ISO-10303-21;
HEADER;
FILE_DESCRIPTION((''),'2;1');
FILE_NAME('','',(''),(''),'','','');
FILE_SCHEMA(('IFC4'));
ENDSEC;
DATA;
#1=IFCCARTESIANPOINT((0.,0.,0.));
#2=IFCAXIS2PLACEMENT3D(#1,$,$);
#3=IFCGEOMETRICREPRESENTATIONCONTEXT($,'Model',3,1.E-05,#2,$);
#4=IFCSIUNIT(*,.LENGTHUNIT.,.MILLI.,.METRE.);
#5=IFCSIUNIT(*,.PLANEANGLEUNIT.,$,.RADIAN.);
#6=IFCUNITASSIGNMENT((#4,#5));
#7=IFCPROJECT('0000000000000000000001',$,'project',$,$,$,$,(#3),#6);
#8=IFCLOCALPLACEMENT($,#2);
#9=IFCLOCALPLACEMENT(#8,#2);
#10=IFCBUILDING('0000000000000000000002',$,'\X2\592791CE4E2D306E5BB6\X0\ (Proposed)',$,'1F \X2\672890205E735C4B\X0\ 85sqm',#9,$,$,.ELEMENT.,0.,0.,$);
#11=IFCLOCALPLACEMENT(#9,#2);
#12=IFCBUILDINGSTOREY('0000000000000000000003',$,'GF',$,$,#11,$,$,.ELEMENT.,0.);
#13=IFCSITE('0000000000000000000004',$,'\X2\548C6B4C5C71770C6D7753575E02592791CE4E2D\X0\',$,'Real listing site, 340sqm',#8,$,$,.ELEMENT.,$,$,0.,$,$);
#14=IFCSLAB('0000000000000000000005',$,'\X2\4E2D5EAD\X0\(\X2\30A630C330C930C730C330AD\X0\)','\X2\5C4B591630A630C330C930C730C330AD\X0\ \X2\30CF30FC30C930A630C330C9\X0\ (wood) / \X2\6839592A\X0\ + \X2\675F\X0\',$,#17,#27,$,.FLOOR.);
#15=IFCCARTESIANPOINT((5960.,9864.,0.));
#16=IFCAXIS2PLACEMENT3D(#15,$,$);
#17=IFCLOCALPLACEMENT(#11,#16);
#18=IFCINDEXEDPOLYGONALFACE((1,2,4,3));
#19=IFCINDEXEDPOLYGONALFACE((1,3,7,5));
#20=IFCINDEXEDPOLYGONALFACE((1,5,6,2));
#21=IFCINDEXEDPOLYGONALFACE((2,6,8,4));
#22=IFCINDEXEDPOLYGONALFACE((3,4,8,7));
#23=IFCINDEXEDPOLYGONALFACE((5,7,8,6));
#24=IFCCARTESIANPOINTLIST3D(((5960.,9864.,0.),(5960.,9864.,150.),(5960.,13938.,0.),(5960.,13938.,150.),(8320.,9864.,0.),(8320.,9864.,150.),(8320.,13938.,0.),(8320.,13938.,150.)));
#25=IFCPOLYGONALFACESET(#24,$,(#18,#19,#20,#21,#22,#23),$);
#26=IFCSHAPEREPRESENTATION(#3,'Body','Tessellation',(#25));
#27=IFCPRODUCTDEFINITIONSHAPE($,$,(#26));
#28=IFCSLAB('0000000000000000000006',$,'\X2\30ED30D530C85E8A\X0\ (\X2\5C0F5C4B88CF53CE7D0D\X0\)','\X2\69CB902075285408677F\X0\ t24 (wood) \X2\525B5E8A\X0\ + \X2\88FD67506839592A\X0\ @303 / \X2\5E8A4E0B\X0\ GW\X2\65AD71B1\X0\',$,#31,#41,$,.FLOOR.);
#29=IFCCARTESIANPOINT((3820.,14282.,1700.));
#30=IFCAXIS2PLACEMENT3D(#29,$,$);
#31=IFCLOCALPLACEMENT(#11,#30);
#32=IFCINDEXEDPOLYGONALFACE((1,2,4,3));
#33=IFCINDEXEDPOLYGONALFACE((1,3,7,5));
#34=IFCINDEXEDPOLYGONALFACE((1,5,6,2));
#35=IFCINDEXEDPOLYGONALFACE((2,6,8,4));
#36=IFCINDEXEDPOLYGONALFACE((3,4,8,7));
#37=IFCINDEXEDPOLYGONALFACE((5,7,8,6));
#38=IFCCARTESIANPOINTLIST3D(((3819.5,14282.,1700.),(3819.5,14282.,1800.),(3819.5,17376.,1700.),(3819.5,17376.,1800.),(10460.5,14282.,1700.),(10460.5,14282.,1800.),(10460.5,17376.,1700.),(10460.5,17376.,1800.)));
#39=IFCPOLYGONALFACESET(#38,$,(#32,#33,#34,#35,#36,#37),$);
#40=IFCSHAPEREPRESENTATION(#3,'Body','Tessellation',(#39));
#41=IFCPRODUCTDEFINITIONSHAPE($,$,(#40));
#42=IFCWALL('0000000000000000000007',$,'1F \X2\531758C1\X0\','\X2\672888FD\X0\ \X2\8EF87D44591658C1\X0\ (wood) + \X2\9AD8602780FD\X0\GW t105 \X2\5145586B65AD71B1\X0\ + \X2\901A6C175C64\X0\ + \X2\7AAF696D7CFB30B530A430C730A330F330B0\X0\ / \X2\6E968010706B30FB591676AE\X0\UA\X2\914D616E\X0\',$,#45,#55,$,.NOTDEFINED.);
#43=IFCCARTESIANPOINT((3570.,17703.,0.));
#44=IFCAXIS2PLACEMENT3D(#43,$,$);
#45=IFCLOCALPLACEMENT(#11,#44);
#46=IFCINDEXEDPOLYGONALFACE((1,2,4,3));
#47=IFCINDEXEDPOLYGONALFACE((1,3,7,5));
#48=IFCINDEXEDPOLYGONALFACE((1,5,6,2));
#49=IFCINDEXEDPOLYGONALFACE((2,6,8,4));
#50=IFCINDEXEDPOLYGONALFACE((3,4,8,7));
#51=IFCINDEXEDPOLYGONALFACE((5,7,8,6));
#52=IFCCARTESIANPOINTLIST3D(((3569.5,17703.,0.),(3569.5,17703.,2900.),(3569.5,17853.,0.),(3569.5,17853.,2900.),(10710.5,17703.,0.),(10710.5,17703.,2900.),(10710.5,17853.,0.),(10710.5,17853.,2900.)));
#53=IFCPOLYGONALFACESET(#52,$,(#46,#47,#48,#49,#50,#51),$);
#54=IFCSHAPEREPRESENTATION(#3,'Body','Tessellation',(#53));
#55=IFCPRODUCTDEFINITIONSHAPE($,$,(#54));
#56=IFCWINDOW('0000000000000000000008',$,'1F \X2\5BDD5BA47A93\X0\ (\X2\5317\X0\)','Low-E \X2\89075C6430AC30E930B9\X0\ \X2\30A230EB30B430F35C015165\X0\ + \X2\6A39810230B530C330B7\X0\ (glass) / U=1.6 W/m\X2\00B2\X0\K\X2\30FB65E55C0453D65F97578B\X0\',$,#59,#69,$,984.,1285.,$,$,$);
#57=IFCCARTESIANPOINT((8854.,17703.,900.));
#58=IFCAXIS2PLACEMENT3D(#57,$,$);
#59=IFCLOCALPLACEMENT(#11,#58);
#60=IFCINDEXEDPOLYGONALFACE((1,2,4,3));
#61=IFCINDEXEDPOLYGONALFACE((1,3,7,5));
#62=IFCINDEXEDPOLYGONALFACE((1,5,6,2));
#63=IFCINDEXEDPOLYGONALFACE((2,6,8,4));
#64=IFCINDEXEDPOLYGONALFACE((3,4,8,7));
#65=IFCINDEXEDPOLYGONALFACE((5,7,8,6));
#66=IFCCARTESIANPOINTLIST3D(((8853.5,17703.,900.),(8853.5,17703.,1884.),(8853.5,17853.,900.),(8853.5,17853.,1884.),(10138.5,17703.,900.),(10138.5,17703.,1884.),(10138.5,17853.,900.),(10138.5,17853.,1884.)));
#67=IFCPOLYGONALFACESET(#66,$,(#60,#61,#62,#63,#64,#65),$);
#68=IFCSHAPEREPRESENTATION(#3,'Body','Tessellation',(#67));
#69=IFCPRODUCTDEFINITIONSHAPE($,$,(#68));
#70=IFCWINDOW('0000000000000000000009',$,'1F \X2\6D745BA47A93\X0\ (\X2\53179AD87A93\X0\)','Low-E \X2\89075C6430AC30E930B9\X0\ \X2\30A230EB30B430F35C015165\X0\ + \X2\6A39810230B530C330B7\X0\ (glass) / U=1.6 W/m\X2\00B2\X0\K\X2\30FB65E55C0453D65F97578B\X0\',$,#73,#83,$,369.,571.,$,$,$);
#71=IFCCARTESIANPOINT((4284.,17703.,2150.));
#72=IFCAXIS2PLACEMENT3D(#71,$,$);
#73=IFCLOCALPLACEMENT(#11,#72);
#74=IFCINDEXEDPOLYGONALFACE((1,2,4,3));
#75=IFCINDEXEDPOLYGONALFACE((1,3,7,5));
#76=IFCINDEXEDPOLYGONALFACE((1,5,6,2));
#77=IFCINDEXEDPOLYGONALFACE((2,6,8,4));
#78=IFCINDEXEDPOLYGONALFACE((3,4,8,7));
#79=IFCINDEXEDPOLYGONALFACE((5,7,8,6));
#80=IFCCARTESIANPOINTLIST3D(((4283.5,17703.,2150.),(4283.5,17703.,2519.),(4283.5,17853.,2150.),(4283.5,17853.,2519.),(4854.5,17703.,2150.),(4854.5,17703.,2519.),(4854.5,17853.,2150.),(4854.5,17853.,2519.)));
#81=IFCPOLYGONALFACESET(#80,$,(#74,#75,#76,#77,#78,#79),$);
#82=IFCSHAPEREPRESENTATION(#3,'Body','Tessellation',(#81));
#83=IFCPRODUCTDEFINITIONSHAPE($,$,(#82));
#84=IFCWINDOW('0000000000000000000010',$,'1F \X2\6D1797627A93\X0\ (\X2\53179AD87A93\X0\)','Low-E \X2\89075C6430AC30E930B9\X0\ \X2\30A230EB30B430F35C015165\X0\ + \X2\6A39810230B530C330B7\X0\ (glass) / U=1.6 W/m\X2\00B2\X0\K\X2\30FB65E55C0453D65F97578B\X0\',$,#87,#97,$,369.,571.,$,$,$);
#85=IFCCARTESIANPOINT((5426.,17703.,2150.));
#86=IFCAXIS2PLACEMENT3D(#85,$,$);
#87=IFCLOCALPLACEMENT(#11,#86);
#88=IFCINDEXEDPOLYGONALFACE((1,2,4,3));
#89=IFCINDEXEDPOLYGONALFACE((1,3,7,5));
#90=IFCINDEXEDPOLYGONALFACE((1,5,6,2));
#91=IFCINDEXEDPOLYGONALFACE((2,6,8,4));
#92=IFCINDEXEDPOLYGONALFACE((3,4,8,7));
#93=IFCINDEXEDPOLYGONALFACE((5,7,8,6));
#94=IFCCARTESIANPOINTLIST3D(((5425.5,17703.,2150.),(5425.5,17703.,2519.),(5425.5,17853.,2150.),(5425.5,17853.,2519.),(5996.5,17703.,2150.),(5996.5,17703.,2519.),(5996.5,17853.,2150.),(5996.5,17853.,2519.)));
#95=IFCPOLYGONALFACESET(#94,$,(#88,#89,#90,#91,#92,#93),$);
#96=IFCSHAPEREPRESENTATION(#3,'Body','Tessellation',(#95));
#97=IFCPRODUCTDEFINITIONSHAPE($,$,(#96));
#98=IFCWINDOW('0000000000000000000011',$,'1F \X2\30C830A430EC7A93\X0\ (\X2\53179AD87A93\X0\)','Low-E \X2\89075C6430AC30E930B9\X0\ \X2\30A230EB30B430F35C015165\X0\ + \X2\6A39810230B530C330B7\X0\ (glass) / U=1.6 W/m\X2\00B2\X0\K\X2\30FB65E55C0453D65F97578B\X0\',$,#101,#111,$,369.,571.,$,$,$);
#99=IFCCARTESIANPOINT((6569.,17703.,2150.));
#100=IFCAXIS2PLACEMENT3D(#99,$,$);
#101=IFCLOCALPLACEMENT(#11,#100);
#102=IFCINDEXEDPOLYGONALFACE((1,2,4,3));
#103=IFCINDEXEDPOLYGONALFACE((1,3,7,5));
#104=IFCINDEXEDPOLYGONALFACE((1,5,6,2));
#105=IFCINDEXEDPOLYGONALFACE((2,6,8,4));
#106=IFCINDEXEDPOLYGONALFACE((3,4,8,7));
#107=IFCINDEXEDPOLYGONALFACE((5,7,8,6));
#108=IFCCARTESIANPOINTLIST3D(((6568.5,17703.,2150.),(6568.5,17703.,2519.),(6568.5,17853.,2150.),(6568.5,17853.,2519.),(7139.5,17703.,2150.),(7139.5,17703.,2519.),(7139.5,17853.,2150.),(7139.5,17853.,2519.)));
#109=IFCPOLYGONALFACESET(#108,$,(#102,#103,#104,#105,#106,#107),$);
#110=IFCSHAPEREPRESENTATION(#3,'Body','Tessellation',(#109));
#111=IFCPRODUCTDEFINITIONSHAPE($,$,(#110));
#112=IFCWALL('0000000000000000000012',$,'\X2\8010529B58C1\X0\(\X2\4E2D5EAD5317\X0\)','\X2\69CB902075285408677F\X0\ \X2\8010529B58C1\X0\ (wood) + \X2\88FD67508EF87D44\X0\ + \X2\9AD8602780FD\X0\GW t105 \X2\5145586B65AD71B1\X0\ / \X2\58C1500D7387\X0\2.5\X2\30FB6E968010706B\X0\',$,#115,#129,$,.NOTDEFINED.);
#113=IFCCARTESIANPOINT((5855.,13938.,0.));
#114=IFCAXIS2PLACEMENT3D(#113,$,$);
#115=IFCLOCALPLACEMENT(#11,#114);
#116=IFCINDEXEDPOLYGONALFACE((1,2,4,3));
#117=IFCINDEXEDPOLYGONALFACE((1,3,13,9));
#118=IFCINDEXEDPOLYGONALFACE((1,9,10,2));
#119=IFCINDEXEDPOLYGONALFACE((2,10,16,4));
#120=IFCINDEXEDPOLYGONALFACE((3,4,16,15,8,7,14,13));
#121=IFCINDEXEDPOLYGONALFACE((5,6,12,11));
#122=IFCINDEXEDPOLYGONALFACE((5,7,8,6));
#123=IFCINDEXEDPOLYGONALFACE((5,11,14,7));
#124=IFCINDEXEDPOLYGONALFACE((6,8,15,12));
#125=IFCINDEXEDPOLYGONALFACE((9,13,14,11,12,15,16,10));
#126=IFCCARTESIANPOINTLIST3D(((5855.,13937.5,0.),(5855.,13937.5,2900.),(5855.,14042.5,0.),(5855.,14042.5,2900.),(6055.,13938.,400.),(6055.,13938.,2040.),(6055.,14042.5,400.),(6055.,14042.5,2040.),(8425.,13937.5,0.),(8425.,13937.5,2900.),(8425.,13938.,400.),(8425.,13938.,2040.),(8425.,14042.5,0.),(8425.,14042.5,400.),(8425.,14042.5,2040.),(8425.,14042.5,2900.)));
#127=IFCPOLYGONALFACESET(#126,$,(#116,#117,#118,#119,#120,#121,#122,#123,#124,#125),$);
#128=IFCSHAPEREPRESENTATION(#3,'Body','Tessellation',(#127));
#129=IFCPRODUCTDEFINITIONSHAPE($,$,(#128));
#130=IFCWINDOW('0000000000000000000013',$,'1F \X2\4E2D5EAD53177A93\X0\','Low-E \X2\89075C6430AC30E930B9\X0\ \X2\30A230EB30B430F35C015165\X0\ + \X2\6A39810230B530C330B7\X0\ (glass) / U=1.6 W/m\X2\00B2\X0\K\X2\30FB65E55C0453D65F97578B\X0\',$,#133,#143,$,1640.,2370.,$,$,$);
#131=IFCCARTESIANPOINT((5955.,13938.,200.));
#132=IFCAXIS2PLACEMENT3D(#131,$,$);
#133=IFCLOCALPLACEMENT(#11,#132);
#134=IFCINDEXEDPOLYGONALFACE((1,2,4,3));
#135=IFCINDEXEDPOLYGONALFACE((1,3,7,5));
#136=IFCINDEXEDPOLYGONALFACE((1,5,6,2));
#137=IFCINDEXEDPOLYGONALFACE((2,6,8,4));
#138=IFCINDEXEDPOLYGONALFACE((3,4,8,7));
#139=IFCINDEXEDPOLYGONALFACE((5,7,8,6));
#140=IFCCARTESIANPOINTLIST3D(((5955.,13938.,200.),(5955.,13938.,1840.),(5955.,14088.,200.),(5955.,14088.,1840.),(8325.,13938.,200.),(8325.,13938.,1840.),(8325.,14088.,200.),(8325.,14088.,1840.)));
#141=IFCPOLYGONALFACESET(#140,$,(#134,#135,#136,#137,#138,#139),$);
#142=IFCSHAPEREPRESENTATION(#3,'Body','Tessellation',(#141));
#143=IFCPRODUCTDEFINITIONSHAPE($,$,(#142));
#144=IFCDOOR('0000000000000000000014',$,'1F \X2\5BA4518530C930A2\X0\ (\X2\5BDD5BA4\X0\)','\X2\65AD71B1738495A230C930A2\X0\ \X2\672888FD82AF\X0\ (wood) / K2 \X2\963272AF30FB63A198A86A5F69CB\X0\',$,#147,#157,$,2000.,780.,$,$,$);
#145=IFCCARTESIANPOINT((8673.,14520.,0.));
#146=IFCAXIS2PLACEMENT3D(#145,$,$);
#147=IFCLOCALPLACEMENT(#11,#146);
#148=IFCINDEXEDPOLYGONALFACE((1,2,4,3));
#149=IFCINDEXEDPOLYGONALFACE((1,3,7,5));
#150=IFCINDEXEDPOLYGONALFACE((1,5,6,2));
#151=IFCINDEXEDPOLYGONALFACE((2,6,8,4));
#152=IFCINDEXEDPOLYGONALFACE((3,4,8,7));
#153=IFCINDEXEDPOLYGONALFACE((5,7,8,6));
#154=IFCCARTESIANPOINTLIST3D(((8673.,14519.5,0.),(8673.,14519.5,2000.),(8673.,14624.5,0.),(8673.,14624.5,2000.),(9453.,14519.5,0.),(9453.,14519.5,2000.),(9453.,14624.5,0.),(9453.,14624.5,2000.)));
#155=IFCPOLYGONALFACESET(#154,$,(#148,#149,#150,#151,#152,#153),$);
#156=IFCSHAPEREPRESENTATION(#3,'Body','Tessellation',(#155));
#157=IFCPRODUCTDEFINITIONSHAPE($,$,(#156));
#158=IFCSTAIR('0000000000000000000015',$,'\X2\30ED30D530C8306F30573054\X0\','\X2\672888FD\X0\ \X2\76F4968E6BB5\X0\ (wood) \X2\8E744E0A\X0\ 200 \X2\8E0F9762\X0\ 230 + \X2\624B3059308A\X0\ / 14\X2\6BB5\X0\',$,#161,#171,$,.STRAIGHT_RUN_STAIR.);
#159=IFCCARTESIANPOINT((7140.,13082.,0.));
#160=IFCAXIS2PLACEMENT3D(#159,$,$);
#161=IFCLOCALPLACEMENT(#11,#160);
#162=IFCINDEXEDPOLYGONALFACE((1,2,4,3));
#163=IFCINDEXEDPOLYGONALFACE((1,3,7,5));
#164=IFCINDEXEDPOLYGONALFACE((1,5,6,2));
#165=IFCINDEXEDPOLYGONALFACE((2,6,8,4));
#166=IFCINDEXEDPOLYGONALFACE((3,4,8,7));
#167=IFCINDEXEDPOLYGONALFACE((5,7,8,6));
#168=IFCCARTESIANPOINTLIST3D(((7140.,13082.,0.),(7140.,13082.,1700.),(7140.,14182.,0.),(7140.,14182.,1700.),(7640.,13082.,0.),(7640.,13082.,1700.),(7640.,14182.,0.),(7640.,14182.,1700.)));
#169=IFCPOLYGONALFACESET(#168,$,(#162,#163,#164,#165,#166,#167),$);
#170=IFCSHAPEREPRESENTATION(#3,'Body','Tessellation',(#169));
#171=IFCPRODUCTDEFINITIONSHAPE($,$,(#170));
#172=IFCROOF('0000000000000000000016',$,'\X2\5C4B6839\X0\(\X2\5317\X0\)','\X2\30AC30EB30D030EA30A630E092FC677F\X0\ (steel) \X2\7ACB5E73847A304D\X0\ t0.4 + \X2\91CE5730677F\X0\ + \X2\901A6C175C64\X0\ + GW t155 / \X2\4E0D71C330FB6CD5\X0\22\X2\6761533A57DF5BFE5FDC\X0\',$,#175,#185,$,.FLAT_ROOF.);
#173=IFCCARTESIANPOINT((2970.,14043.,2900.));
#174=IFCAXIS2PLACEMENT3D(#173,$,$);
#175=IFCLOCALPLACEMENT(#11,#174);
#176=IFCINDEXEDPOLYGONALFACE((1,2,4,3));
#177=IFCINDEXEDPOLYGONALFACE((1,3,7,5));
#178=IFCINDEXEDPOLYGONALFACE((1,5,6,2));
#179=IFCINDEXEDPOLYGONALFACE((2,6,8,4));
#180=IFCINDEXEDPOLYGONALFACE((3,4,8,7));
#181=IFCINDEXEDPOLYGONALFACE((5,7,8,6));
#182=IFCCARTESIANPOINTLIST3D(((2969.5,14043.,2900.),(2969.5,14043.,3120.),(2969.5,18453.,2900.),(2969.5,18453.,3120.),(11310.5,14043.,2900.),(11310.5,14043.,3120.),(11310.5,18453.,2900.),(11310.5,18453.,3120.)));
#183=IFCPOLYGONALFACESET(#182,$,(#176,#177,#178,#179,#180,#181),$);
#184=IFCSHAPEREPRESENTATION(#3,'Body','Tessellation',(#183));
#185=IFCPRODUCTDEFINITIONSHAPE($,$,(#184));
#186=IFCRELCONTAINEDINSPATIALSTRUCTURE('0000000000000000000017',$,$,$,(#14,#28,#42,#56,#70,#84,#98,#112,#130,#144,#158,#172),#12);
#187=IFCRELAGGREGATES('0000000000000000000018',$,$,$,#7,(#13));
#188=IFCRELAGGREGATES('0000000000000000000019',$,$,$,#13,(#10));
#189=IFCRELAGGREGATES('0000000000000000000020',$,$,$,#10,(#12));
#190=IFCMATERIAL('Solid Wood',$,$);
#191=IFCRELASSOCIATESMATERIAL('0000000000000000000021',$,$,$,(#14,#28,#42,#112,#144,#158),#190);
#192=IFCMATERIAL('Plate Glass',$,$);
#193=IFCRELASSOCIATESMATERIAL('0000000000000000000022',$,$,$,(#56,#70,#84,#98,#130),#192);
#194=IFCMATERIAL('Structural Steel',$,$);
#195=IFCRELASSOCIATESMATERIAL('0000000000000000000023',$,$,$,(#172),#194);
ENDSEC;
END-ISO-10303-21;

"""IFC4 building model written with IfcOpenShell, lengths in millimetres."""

from ifc_helpers import new_model, si_unit, frame, frame_2d, origin, place, context, project, spatial, rectangle, extrude, material, element, fill, save


model = new_model("IFC4")

# Units and contexts
model_context = context("Model", 3, precision=1e-05, world=origin())
ifc_project = project(units=[si_unit("LENGTHUNIT", "METRE", prefix="MILLI"), si_unit("PLANEANGLEUNIT", "RADIAN")], contexts=[model_context])

# Site, building, storey
site_placement = place(None, origin())
site = spatial("IfcSite", under=ifc_project, at=site_placement, Name="和歌山県海南市大野中", ObjectType="Real listing site, 340sqm", CompositionType="ELEMENT", RefElevation=0.0)
building_placement = place(site_placement, origin())
building = spatial("IfcBuilding", under=site, at=building_placement, Name="大野中の家 (Proposed)", ObjectType="1F 木造平屋 85sqm", CompositionType="ELEMENT", ElevationOfRefHeight=0.0, ElevationOfTerrain=0.0)
storey_placement = place(building_placement, origin())
storey = spatial("IfcBuildingStorey", under=building, at=storey_placement, Name="GF", CompositionType="ELEMENT", Elevation=0.0)

# Slabs
ifc_material_1 = material(Name="Solid Wood")
slab_1_placement = place(storey_placement, frame((5960.0, 9864.0, 0.0)))
element("IfcSlab", 1, at=slab_1_placement, inside=storey, material=ifc_material_1, Name="中庭(ウッドデッキ)", Description="屋外ウッドデッキ ハードウッド (wood) / 根太 + 束", PredefinedType="FLOOR", context=model_context, shape_type="SweptSolid", body=[
    extrude(rectangle(XDim=2360.0, YDim=4074.0, at=frame_2d((1180.0, 2037.0))), frame((5960.0, 9864.0, 0.0)), (0.0, 0.0, 1.0), 150.0),
])
slab_2_placement = place(storey_placement, frame((3820.0, 14282.0, 1700.0)))
element("IfcSlab", 2, at=slab_2_placement, inside=storey, material=ifc_material_1, Name="ロフト床 (小屋裏収納)", Description="構造用合板 t24 (wood) 剛床 + 製材根太 @303 / 床下 GW断熱", PredefinedType="FLOOR", context=model_context, shape_type="SweptSolid", body=[
    extrude(rectangle(XDim=6641.0, YDim=3094.0, at=frame_2d((3320.0, 1547.0))), frame((3820.0, 14282.0, 1700.0)), (0.0, 0.0, 1.0), 100.0),
])

# Wall, openings, windows
wall_1_placement = place(storey_placement, frame((3570.0, 17703.0, 0.0)))
wall_1 = element("IfcWall", 3, at=wall_1_placement, inside=storey, material=ifc_material_1, Name="1F 北壁", Description="木製 軸組外壁 (wood) + 高性能GW t105 充填断熱 + 通気層 + 窯業系サイディング / 準耐火・外皮UA配慮", PredefinedType="NOTDEFINED", context=model_context, shape_type="SweptSolid", body=[
    extrude(rectangle(XDim=7141.0, YDim=150.0, at=frame_2d((3570.0, 75.0))), frame((3570.0, 17703.0, 0.0)), (0.0, 0.0, 1.0), 2900.0),
])
opening_1_placement = place(storey_placement, frame((8854.0, 17703.0, 900.0)))
opening_1 = element("IfcOpeningElement", 4, at=opening_1_placement, cuts=wall_1, PredefinedType="NOTDEFINED", context=model_context, shape_type="SweptSolid", body=[
    extrude(rectangle(XDim=1285.0, YDim=150.0, at=frame_2d((642.0, 75.0))), frame((8854.0, 17703.0, 900.0)), (0.0, 0.0, 1.0), 984.0),
])
opening_2_placement = place(storey_placement, frame((4284.0, 17703.0, 2150.0)))
opening_2 = element("IfcOpeningElement", 5, at=opening_2_placement, cuts=wall_1, PredefinedType="NOTDEFINED", context=model_context, shape_type="SweptSolid", body=[
    extrude(rectangle(XDim=571.0, YDim=150.0, at=frame_2d((285.0, 75.0))), frame((4284.0, 17703.0, 2150.0)), (0.0, 0.0, 1.0), 369.0),
])
opening_3_placement = place(storey_placement, frame((5426.0, 17703.0, 2150.0)))
opening_3 = element("IfcOpeningElement", 6, at=opening_3_placement, cuts=wall_1, PredefinedType="NOTDEFINED", context=model_context, shape_type="SweptSolid", body=[
    extrude(rectangle(XDim=571.0, YDim=150.0, at=frame_2d((285.0, 75.0))), frame((5426.0, 17703.0, 2150.0)), (0.0, 0.0, 1.0), 369.0),
])
opening_4_placement = place(storey_placement, frame((6569.0, 17703.0, 2150.0)))
opening_4 = element("IfcOpeningElement", 7, at=opening_4_placement, cuts=wall_1, PredefinedType="NOTDEFINED", context=model_context, shape_type="SweptSolid", body=[
    extrude(rectangle(XDim=571.0, YDim=150.0, at=frame_2d((285.0, 75.0))), frame((6569.0, 17703.0, 2150.0)), (0.0, 0.0, 1.0), 369.0),
])
ifc_material_2 = material(Name="Plate Glass")
window_1_placement = place(storey_placement, frame((8854.0, 17703.0, 900.0)))
window_1 = element("IfcWindow", 8, at=window_1_placement, inside=storey, material=ifc_material_2, Name="1F 寝室窓 (北)", Description="Low-E 複層ガラス アルゴン封入 + 樹脂サッシ (glass) / U=1.6 W/m²K・日射取得型", OverallHeight=984.0, OverallWidth=1285.0, context=model_context, shape_type="SweptSolid", body=[
    extrude(rectangle(XDim=1285.0, YDim=150.0, at=frame_2d((642.0, 75.0))), frame((8854.0, 17703.0, 900.0)), (0.0, 0.0, 1.0), 984.0),
])
fill(opening_1, window_1)
window_2_placement = place(storey_placement, frame((4284.0, 17703.0, 2150.0)))
window_2 = element("IfcWindow", 9, at=window_2_placement, inside=storey, material=ifc_material_2, Name="1F 浴室窓 (北高窓)", Description="Low-E 複層ガラス アルゴン封入 + 樹脂サッシ (glass) / U=1.6 W/m²K・日射取得型", OverallHeight=369.0, OverallWidth=571.0, context=model_context, shape_type="SweptSolid", body=[
    extrude(rectangle(XDim=571.0, YDim=150.0, at=frame_2d((285.0, 75.0))), frame((4284.0, 17703.0, 2150.0)), (0.0, 0.0, 1.0), 369.0),
])
fill(opening_2, window_2)
window_3_placement = place(storey_placement, frame((5426.0, 17703.0, 2150.0)))
window_3 = element("IfcWindow", 10, at=window_3_placement, inside=storey, material=ifc_material_2, Name="1F 洗面窓 (北高窓)", Description="Low-E 複層ガラス アルゴン封入 + 樹脂サッシ (glass) / U=1.6 W/m²K・日射取得型", OverallHeight=369.0, OverallWidth=571.0, context=model_context, shape_type="SweptSolid", body=[
    extrude(rectangle(XDim=571.0, YDim=150.0, at=frame_2d((285.0, 75.0))), frame((5426.0, 17703.0, 2150.0)), (0.0, 0.0, 1.0), 369.0),
])
fill(opening_3, window_3)
window_4_placement = place(storey_placement, frame((6569.0, 17703.0, 2150.0)))
window_4 = element("IfcWindow", 11, at=window_4_placement, inside=storey, material=ifc_material_2, Name="1F トイレ窓 (北高窓)", Description="Low-E 複層ガラス アルゴン封入 + 樹脂サッシ (glass) / U=1.6 W/m²K・日射取得型", OverallHeight=369.0, OverallWidth=571.0, context=model_context, shape_type="SweptSolid", body=[
    extrude(rectangle(XDim=571.0, YDim=150.0, at=frame_2d((285.0, 75.0))), frame((6569.0, 17703.0, 2150.0)), (0.0, 0.0, 1.0), 369.0),
])
fill(opening_4, window_4)

# Wall, opening, window
wall_2_placement = place(storey_placement, frame((5855.0, 13938.0, 0.0)))
wall_2 = element("IfcWall", 12, at=wall_2_placement, inside=storey, material=ifc_material_1, Name="耐力壁(中庭北)", Description="構造用合板 耐力壁 (wood) + 製材軸組 + 高性能GW t105 充填断熱 / 壁倍率2.5・準耐火", PredefinedType="NOTDEFINED", context=model_context, shape_type="SweptSolid", body=[
    extrude(rectangle(XDim=2570.0, YDim=105.0, at=frame_2d((1285.0, 52.0))), frame((5855.0, 13938.0, 0.0)), (0.0, 0.0, 1.0), 2900.0),
])
opening_5_placement = place(storey_placement, frame((5955.0, 13938.0, 200.0)))
opening_5 = element("IfcOpeningElement", 13, at=opening_5_placement, cuts=wall_2, PredefinedType="NOTDEFINED", context=model_context, shape_type="SweptSolid", body=[
    extrude(rectangle(XDim=2370.0, YDim=150.0, at=frame_2d((1185.0, 75.0))), frame((5955.0, 13938.0, 200.0)), (0.0, 0.0, 1.0), 1640.0),
])
window_5_placement = place(storey_placement, frame((5955.0, 13938.0, 200.0)))
window_5 = element("IfcWindow", 14, at=window_5_placement, inside=storey, material=ifc_material_2, Name="1F 中庭北窓", Description="Low-E 複層ガラス アルゴン封入 + 樹脂サッシ (glass) / U=1.6 W/m²K・日射取得型", OverallHeight=1640.0, OverallWidth=2370.0, context=model_context, shape_type="SweptSolid", body=[
    extrude(rectangle(XDim=2370.0, YDim=150.0, at=frame_2d((1185.0, 75.0))), frame((5955.0, 13938.0, 200.0)), (0.0, 0.0, 1.0), 1640.0),
])
fill(opening_5, window_5)

# Door
door_1_placement = place(storey_placement, frame((8673.0, 14520.0, 0.0)))
element("IfcDoor", 15, at=door_1_placement, inside=storey, material=ifc_material_1, Name="1F 室内ドア (寝室)", Description="断熱玄関ドア 木製芯 (wood) / K2 防犯・採風機構", OverallHeight=2000.0, OverallWidth=780.0, context=model_context, shape_type="SweptSolid", body=[
    extrude(rectangle(XDim=780.0, YDim=105.0, at=frame_2d((390.0, 52.0))), frame((8673.0, 14520.0, 0.0)), (0.0, 0.0, 1.0), 2000.0),
])

# Stair
stair_placement = place(storey_placement, frame((7140.0, 13082.0, 0.0)))
element("IfcStair", 16, at=stair_placement, inside=storey, material=ifc_material_1, Name="ロフトはしご", Description="木製 直階段 (wood) 蹴上 200 踏面 230 + 手すり / 14段", PredefinedType="STRAIGHT_RUN_STAIR", context=model_context, shape_type="SweptSolid", body=[
    extrude(rectangle(XDim=500.0, YDim=1100.0, at=frame_2d((250.0, 550.0))), frame((7140.0, 13082.0, 0.0)), (0.0, 0.0, 1.0), 1700.0),
])

# Roof
ifc_material_3 = material(Name="Structural Steel")
roof_1_placement = place(storey_placement, frame((2970.0, 14043.0, 2900.0)))
element("IfcRoof", 17, at=roof_1_placement, inside=storey, material=ifc_material_3, Name="屋根(北)", Description="ガルバリウム鋼板 (steel) 立平葺き t0.4 + 野地板 + 通気層 + GW t155 / 不燃・法22条区域対応", PredefinedType="FLAT_ROOF", context=model_context, shape_type="SweptSolid", body=[
    extrude(rectangle(XDim=8341.0, YDim=4410.0, at=frame_2d((4170.0, 2205.0))), frame((2970.0, 14043.0, 2900.0)), (0.0, 0.0, 1.0), 220.0),
])

save(model, "model.ifc")
